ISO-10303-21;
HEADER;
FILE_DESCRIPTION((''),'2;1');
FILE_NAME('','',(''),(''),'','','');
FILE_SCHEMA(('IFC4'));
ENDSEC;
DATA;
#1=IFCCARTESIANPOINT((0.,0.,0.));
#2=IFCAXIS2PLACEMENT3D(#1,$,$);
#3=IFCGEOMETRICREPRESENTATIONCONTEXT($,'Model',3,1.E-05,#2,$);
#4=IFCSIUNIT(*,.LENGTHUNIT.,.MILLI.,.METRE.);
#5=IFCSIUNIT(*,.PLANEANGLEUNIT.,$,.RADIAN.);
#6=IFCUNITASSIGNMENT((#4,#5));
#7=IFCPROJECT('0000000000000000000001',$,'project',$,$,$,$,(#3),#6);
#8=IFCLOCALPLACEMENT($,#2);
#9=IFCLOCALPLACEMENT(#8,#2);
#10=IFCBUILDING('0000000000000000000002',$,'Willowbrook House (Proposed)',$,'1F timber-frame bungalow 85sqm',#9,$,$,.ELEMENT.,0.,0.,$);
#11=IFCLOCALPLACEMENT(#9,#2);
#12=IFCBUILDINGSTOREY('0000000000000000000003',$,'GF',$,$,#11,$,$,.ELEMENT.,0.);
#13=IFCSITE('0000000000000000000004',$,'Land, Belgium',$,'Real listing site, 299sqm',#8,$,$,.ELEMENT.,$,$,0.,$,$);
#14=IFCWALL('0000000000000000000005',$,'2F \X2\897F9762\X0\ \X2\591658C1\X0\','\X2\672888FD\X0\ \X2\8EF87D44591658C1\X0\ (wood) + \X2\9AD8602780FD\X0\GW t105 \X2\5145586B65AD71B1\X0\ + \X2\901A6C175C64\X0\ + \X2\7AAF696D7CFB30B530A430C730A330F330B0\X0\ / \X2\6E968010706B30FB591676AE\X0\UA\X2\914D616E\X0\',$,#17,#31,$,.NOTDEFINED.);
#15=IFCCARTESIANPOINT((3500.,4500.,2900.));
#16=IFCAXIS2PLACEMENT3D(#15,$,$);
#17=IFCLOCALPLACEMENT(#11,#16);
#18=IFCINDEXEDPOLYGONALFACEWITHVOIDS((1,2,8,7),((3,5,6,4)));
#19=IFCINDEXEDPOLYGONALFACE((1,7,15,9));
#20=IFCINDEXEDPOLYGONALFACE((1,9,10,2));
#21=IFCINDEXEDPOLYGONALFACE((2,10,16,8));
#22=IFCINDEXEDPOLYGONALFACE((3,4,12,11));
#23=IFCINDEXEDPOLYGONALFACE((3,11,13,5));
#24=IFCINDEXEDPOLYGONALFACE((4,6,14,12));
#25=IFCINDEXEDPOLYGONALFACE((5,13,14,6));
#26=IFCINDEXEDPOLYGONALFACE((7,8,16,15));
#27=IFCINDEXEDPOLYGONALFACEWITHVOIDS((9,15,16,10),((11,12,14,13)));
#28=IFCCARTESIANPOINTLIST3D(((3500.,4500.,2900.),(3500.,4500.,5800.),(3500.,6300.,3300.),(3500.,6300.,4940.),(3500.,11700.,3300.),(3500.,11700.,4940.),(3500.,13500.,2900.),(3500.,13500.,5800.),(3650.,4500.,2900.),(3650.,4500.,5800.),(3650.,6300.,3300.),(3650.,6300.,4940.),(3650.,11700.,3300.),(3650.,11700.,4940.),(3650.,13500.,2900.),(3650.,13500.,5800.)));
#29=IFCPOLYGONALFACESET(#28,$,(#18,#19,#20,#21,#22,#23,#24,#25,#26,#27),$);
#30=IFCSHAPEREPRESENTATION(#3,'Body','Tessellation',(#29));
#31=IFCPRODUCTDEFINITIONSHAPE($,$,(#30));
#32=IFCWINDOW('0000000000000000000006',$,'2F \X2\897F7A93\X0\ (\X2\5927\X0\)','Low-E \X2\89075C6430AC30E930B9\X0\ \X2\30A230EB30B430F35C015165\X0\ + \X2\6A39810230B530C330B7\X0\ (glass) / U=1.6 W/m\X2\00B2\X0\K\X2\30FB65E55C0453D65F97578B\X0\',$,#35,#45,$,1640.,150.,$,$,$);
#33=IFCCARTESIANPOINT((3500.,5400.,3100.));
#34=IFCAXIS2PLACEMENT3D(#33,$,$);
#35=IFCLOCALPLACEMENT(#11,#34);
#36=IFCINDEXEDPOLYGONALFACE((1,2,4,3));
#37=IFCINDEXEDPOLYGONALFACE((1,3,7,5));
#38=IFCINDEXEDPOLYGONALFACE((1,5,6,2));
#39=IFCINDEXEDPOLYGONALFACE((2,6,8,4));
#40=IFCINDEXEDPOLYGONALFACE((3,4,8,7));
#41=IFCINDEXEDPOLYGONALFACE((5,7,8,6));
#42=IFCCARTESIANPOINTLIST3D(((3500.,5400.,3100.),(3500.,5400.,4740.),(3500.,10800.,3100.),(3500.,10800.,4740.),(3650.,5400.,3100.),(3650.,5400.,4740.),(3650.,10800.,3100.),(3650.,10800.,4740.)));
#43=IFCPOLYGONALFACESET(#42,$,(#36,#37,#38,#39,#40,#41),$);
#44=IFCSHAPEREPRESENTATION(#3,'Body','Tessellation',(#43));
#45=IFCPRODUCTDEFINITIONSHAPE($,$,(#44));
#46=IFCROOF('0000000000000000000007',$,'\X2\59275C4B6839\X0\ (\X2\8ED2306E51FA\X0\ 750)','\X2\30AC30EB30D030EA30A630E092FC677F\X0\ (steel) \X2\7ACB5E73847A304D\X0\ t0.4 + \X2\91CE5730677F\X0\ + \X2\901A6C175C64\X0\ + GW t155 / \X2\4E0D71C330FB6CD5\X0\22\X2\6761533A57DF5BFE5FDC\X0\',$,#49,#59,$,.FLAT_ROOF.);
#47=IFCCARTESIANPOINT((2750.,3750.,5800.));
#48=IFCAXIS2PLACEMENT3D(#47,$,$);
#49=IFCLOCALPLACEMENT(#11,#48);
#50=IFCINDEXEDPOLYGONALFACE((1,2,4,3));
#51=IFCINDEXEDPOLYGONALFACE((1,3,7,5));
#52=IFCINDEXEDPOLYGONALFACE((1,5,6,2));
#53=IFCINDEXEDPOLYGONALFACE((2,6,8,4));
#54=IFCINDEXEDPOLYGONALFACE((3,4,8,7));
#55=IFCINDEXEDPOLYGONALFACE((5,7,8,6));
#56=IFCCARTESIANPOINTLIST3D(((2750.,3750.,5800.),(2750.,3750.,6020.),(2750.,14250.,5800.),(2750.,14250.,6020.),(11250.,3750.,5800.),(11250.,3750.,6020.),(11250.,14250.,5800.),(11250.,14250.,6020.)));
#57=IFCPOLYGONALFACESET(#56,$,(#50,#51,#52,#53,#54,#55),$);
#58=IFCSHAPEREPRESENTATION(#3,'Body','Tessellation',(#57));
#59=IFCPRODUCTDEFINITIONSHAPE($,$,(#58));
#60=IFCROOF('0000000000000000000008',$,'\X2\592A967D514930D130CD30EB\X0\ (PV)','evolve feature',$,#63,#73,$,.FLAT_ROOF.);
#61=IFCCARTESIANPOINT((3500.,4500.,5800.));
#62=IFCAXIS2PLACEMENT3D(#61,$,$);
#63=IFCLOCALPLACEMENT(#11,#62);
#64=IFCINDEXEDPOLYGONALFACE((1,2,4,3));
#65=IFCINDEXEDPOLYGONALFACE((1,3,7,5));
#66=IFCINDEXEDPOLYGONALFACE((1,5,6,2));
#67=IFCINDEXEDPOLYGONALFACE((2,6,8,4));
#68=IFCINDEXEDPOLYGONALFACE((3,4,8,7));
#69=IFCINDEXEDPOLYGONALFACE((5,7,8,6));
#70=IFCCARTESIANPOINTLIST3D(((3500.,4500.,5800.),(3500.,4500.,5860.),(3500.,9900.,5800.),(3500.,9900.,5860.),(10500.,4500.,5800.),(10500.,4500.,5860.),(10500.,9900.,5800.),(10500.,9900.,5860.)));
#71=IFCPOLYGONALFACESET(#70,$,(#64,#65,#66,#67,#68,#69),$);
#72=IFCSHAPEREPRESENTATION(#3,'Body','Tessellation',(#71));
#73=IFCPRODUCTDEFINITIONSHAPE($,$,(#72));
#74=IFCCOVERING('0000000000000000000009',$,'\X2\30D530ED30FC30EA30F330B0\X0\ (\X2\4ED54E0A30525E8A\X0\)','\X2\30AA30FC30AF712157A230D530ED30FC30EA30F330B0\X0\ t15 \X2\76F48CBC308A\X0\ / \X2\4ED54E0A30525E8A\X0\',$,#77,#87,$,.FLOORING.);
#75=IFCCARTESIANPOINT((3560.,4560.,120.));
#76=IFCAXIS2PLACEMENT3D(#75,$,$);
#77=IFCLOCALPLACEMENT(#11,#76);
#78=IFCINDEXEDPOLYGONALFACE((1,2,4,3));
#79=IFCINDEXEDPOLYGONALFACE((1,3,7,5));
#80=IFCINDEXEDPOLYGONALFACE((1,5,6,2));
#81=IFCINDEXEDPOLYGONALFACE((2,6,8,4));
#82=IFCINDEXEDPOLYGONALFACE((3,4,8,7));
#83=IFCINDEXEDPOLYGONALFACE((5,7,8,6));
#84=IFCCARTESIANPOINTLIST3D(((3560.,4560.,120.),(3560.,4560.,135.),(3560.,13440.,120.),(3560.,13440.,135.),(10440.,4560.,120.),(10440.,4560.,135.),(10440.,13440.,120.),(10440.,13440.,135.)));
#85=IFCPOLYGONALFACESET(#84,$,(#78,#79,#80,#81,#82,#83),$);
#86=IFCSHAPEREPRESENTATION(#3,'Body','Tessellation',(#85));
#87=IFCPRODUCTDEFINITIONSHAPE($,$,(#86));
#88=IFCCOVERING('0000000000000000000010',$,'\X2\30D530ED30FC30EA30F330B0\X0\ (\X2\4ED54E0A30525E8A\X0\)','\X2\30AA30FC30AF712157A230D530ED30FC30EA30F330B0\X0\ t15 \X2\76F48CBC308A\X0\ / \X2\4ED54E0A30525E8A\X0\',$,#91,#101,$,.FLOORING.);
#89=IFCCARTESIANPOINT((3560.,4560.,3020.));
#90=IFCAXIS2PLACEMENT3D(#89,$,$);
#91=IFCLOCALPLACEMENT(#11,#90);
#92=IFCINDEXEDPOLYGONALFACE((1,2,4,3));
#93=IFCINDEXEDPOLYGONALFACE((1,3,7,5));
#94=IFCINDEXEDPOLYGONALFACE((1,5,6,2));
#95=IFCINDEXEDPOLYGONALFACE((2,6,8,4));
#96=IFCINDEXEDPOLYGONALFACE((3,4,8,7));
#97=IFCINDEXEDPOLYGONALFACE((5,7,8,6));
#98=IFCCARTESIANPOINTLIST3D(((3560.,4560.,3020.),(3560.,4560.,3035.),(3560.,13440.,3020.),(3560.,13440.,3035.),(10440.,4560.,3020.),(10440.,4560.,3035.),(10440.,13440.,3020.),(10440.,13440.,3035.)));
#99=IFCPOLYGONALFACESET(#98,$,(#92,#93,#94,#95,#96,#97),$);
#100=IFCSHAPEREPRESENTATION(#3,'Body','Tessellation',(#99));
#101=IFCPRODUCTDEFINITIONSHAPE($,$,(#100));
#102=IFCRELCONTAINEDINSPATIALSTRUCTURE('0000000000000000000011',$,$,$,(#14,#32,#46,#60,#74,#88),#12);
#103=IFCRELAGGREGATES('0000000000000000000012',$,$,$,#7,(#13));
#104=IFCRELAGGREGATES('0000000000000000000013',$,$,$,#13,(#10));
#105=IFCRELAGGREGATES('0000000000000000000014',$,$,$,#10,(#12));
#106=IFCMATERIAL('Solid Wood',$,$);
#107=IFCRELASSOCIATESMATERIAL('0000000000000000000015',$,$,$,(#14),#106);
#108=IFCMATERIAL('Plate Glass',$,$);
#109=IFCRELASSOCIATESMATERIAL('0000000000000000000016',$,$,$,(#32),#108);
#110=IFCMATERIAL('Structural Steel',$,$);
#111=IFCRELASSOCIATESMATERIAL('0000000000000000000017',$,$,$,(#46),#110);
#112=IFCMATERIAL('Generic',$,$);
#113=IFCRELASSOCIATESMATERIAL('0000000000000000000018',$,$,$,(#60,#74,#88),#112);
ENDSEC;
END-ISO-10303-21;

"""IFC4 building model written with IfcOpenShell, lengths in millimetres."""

from ifc_helpers import new_model, si_unit, frame, frame_2d, origin, place, context, project, spatial, rectangle, extrude, material, element, fill, save


model = new_model("IFC4")

# Units and contexts
model_context = context("Model", 3, precision=1e-05, world=origin())
ifc_project = project(units=[si_unit("LENGTHUNIT", "METRE", prefix="MILLI"), si_unit("PLANEANGLEUNIT", "RADIAN")], contexts=[model_context])

# Site, building, storey
site_placement = place(None, origin())
site = spatial("IfcSite", under=ifc_project, at=site_placement, Name="Land, Belgium", ObjectType="Real listing site, 299sqm", CompositionType="ELEMENT", RefElevation=0.0)
building_placement = place(site_placement, origin())
building = spatial("IfcBuilding", under=site, at=building_placement, Name="Willowbrook House (Proposed)", ObjectType="1F timber-frame bungalow 85sqm", CompositionType="ELEMENT", ElevationOfRefHeight=0.0, ElevationOfTerrain=0.0)
storey_placement = place(building_placement, origin())
storey = spatial("IfcBuildingStorey", under=building, at=storey_placement, Name="GF", CompositionType="ELEMENT", Elevation=0.0)

# Shared definitions
ifc_material_1 = material(Name="Solid Wood")
ifc_material_2 = material(Name="Generic")

# Shared definitions
ifc_material_3 = material(Name="Plate Glass")

# Wall, opening, window
wall_1_placement = place(storey_placement, frame((3500.0, 4500.0, 2900.0)))
wall_1 = element("IfcWall", 1, at=wall_1_placement, inside=storey, material=ifc_material_1, Name="2F 西面 外壁", Description="木製 軸組外壁 (wood) + 高性能GW t105 充填断熱 + 通気層 + 窯業系サイディング / 準耐火・外皮UA配慮", PredefinedType="NOTDEFINED", context=model_context, shape_type="SweptSolid", body=[
    extrude(rectangle(XDim=150.0, YDim=9000.0, at=frame_2d((75.0, 4500.0))), frame((3500.0, 4500.0, 2900.0)), (0.0, 0.0, 1.0), 2900.0),
])
opening_1_placement = place(storey_placement, frame((3500.0, 5400.0, 3100.0)))
opening_1 = element("IfcOpeningElement", 2, at=opening_1_placement, cuts=wall_1, PredefinedType="NOTDEFINED", context=model_context, shape_type="SweptSolid", body=[
    extrude(rectangle(XDim=150.0, YDim=5400.0, at=frame_2d((75.0, 2700.0))), frame((3500.0, 5400.0, 3100.0)), (0.0, 0.0, 1.0), 1640.0),
])
window_1_placement = place(storey_placement, frame((3500.0, 5400.0, 3100.0)))
window_1 = element("IfcWindow", 3, at=window_1_placement, inside=storey, material=ifc_material_3, Name="2F 西窓 (大)", Description="Low-E 複層ガラス アルゴン封入 + 樹脂サッシ (glass) / U=1.6 W/m²K・日射取得型", OverallHeight=1640.0, OverallWidth=150.0, context=model_context, shape_type="SweptSolid", body=[
    extrude(rectangle(XDim=150.0, YDim=5400.0, at=frame_2d((75.0, 2700.0))), frame((3500.0, 5400.0, 3100.0)), (0.0, 0.0, 1.0), 1640.0),
])
fill(opening_1, window_1)

# Roofs
ifc_material_4 = material(Name="Structural Steel")
roof_1_placement = place(storey_placement, frame((2750.0, 3750.0, 5800.0)))
element("IfcRoof", 4, at=roof_1_placement, inside=storey, material=ifc_material_4, Name="大屋根 (軒の出 750)", Description="ガルバリウム鋼板 (steel) 立平葺き t0.4 + 野地板 + 通気層 + GW t155 / 不燃・法22条区域対応", PredefinedType="FLAT_ROOF", context=model_context, shape_type="SweptSolid", body=[
    extrude(rectangle(XDim=8500.0, YDim=10500.0, at=frame_2d((4250.0, 5250.0))), frame((2750.0, 3750.0, 5800.0)), (0.0, 0.0, 1.0), 220.0),
])
roof_2_placement = place(storey_placement, frame((3500.0, 4500.0, 5800.0)))
element("IfcRoof", 5, at=roof_2_placement, inside=storey, material=ifc_material_2, Name="太陽光パネル (PV)", Description="evolve feature", PredefinedType="FLAT_ROOF", context=model_context, shape_type="SweptSolid", body=[
    extrude(rectangle(XDim=7000.0, YDim=5400.0, at=frame_2d((3500.0, 2700.0))), frame((3500.0, 4500.0, 5800.0)), (0.0, 0.0, 1.0), 60.0),
])

# Coverings
covering_1_placement = place(storey_placement, frame((3560.0, 4560.0, 120.0)))
element("IfcCovering", 6, at=covering_1_placement, inside=storey, material=ifc_material_2, Name="フローリング (仕上げ床)", Description="オーク無垢フローリング t15 直貼り / 仕上げ床", PredefinedType="FLOORING", context=model_context, shape_type="SweptSolid", body=[
    extrude(rectangle(XDim=6880.0, YDim=8880.0, at=frame_2d((3440.0, 4440.0))), frame((3560.0, 4560.0, 120.0)), (0.0, 0.0, 1.0), 15.0),
])
covering_2_placement = place(storey_placement, frame((3560.0, 4560.0, 3020.0)))
element("IfcCovering", 7, at=covering_2_placement, inside=storey, material=ifc_material_2, Name="フローリング (仕上げ床)", Description="オーク無垢フローリング t15 直貼り / 仕上げ床", PredefinedType="FLOORING", context=model_context, shape_type="SweptSolid", body=[
    extrude(rectangle(XDim=6880.0, YDim=8880.0, at=frame_2d((3440.0, 4440.0))), frame((3560.0, 4560.0, 3020.0)), (0.0, 0.0, 1.0), 15.0),
])

save(model, "model.ifc")
